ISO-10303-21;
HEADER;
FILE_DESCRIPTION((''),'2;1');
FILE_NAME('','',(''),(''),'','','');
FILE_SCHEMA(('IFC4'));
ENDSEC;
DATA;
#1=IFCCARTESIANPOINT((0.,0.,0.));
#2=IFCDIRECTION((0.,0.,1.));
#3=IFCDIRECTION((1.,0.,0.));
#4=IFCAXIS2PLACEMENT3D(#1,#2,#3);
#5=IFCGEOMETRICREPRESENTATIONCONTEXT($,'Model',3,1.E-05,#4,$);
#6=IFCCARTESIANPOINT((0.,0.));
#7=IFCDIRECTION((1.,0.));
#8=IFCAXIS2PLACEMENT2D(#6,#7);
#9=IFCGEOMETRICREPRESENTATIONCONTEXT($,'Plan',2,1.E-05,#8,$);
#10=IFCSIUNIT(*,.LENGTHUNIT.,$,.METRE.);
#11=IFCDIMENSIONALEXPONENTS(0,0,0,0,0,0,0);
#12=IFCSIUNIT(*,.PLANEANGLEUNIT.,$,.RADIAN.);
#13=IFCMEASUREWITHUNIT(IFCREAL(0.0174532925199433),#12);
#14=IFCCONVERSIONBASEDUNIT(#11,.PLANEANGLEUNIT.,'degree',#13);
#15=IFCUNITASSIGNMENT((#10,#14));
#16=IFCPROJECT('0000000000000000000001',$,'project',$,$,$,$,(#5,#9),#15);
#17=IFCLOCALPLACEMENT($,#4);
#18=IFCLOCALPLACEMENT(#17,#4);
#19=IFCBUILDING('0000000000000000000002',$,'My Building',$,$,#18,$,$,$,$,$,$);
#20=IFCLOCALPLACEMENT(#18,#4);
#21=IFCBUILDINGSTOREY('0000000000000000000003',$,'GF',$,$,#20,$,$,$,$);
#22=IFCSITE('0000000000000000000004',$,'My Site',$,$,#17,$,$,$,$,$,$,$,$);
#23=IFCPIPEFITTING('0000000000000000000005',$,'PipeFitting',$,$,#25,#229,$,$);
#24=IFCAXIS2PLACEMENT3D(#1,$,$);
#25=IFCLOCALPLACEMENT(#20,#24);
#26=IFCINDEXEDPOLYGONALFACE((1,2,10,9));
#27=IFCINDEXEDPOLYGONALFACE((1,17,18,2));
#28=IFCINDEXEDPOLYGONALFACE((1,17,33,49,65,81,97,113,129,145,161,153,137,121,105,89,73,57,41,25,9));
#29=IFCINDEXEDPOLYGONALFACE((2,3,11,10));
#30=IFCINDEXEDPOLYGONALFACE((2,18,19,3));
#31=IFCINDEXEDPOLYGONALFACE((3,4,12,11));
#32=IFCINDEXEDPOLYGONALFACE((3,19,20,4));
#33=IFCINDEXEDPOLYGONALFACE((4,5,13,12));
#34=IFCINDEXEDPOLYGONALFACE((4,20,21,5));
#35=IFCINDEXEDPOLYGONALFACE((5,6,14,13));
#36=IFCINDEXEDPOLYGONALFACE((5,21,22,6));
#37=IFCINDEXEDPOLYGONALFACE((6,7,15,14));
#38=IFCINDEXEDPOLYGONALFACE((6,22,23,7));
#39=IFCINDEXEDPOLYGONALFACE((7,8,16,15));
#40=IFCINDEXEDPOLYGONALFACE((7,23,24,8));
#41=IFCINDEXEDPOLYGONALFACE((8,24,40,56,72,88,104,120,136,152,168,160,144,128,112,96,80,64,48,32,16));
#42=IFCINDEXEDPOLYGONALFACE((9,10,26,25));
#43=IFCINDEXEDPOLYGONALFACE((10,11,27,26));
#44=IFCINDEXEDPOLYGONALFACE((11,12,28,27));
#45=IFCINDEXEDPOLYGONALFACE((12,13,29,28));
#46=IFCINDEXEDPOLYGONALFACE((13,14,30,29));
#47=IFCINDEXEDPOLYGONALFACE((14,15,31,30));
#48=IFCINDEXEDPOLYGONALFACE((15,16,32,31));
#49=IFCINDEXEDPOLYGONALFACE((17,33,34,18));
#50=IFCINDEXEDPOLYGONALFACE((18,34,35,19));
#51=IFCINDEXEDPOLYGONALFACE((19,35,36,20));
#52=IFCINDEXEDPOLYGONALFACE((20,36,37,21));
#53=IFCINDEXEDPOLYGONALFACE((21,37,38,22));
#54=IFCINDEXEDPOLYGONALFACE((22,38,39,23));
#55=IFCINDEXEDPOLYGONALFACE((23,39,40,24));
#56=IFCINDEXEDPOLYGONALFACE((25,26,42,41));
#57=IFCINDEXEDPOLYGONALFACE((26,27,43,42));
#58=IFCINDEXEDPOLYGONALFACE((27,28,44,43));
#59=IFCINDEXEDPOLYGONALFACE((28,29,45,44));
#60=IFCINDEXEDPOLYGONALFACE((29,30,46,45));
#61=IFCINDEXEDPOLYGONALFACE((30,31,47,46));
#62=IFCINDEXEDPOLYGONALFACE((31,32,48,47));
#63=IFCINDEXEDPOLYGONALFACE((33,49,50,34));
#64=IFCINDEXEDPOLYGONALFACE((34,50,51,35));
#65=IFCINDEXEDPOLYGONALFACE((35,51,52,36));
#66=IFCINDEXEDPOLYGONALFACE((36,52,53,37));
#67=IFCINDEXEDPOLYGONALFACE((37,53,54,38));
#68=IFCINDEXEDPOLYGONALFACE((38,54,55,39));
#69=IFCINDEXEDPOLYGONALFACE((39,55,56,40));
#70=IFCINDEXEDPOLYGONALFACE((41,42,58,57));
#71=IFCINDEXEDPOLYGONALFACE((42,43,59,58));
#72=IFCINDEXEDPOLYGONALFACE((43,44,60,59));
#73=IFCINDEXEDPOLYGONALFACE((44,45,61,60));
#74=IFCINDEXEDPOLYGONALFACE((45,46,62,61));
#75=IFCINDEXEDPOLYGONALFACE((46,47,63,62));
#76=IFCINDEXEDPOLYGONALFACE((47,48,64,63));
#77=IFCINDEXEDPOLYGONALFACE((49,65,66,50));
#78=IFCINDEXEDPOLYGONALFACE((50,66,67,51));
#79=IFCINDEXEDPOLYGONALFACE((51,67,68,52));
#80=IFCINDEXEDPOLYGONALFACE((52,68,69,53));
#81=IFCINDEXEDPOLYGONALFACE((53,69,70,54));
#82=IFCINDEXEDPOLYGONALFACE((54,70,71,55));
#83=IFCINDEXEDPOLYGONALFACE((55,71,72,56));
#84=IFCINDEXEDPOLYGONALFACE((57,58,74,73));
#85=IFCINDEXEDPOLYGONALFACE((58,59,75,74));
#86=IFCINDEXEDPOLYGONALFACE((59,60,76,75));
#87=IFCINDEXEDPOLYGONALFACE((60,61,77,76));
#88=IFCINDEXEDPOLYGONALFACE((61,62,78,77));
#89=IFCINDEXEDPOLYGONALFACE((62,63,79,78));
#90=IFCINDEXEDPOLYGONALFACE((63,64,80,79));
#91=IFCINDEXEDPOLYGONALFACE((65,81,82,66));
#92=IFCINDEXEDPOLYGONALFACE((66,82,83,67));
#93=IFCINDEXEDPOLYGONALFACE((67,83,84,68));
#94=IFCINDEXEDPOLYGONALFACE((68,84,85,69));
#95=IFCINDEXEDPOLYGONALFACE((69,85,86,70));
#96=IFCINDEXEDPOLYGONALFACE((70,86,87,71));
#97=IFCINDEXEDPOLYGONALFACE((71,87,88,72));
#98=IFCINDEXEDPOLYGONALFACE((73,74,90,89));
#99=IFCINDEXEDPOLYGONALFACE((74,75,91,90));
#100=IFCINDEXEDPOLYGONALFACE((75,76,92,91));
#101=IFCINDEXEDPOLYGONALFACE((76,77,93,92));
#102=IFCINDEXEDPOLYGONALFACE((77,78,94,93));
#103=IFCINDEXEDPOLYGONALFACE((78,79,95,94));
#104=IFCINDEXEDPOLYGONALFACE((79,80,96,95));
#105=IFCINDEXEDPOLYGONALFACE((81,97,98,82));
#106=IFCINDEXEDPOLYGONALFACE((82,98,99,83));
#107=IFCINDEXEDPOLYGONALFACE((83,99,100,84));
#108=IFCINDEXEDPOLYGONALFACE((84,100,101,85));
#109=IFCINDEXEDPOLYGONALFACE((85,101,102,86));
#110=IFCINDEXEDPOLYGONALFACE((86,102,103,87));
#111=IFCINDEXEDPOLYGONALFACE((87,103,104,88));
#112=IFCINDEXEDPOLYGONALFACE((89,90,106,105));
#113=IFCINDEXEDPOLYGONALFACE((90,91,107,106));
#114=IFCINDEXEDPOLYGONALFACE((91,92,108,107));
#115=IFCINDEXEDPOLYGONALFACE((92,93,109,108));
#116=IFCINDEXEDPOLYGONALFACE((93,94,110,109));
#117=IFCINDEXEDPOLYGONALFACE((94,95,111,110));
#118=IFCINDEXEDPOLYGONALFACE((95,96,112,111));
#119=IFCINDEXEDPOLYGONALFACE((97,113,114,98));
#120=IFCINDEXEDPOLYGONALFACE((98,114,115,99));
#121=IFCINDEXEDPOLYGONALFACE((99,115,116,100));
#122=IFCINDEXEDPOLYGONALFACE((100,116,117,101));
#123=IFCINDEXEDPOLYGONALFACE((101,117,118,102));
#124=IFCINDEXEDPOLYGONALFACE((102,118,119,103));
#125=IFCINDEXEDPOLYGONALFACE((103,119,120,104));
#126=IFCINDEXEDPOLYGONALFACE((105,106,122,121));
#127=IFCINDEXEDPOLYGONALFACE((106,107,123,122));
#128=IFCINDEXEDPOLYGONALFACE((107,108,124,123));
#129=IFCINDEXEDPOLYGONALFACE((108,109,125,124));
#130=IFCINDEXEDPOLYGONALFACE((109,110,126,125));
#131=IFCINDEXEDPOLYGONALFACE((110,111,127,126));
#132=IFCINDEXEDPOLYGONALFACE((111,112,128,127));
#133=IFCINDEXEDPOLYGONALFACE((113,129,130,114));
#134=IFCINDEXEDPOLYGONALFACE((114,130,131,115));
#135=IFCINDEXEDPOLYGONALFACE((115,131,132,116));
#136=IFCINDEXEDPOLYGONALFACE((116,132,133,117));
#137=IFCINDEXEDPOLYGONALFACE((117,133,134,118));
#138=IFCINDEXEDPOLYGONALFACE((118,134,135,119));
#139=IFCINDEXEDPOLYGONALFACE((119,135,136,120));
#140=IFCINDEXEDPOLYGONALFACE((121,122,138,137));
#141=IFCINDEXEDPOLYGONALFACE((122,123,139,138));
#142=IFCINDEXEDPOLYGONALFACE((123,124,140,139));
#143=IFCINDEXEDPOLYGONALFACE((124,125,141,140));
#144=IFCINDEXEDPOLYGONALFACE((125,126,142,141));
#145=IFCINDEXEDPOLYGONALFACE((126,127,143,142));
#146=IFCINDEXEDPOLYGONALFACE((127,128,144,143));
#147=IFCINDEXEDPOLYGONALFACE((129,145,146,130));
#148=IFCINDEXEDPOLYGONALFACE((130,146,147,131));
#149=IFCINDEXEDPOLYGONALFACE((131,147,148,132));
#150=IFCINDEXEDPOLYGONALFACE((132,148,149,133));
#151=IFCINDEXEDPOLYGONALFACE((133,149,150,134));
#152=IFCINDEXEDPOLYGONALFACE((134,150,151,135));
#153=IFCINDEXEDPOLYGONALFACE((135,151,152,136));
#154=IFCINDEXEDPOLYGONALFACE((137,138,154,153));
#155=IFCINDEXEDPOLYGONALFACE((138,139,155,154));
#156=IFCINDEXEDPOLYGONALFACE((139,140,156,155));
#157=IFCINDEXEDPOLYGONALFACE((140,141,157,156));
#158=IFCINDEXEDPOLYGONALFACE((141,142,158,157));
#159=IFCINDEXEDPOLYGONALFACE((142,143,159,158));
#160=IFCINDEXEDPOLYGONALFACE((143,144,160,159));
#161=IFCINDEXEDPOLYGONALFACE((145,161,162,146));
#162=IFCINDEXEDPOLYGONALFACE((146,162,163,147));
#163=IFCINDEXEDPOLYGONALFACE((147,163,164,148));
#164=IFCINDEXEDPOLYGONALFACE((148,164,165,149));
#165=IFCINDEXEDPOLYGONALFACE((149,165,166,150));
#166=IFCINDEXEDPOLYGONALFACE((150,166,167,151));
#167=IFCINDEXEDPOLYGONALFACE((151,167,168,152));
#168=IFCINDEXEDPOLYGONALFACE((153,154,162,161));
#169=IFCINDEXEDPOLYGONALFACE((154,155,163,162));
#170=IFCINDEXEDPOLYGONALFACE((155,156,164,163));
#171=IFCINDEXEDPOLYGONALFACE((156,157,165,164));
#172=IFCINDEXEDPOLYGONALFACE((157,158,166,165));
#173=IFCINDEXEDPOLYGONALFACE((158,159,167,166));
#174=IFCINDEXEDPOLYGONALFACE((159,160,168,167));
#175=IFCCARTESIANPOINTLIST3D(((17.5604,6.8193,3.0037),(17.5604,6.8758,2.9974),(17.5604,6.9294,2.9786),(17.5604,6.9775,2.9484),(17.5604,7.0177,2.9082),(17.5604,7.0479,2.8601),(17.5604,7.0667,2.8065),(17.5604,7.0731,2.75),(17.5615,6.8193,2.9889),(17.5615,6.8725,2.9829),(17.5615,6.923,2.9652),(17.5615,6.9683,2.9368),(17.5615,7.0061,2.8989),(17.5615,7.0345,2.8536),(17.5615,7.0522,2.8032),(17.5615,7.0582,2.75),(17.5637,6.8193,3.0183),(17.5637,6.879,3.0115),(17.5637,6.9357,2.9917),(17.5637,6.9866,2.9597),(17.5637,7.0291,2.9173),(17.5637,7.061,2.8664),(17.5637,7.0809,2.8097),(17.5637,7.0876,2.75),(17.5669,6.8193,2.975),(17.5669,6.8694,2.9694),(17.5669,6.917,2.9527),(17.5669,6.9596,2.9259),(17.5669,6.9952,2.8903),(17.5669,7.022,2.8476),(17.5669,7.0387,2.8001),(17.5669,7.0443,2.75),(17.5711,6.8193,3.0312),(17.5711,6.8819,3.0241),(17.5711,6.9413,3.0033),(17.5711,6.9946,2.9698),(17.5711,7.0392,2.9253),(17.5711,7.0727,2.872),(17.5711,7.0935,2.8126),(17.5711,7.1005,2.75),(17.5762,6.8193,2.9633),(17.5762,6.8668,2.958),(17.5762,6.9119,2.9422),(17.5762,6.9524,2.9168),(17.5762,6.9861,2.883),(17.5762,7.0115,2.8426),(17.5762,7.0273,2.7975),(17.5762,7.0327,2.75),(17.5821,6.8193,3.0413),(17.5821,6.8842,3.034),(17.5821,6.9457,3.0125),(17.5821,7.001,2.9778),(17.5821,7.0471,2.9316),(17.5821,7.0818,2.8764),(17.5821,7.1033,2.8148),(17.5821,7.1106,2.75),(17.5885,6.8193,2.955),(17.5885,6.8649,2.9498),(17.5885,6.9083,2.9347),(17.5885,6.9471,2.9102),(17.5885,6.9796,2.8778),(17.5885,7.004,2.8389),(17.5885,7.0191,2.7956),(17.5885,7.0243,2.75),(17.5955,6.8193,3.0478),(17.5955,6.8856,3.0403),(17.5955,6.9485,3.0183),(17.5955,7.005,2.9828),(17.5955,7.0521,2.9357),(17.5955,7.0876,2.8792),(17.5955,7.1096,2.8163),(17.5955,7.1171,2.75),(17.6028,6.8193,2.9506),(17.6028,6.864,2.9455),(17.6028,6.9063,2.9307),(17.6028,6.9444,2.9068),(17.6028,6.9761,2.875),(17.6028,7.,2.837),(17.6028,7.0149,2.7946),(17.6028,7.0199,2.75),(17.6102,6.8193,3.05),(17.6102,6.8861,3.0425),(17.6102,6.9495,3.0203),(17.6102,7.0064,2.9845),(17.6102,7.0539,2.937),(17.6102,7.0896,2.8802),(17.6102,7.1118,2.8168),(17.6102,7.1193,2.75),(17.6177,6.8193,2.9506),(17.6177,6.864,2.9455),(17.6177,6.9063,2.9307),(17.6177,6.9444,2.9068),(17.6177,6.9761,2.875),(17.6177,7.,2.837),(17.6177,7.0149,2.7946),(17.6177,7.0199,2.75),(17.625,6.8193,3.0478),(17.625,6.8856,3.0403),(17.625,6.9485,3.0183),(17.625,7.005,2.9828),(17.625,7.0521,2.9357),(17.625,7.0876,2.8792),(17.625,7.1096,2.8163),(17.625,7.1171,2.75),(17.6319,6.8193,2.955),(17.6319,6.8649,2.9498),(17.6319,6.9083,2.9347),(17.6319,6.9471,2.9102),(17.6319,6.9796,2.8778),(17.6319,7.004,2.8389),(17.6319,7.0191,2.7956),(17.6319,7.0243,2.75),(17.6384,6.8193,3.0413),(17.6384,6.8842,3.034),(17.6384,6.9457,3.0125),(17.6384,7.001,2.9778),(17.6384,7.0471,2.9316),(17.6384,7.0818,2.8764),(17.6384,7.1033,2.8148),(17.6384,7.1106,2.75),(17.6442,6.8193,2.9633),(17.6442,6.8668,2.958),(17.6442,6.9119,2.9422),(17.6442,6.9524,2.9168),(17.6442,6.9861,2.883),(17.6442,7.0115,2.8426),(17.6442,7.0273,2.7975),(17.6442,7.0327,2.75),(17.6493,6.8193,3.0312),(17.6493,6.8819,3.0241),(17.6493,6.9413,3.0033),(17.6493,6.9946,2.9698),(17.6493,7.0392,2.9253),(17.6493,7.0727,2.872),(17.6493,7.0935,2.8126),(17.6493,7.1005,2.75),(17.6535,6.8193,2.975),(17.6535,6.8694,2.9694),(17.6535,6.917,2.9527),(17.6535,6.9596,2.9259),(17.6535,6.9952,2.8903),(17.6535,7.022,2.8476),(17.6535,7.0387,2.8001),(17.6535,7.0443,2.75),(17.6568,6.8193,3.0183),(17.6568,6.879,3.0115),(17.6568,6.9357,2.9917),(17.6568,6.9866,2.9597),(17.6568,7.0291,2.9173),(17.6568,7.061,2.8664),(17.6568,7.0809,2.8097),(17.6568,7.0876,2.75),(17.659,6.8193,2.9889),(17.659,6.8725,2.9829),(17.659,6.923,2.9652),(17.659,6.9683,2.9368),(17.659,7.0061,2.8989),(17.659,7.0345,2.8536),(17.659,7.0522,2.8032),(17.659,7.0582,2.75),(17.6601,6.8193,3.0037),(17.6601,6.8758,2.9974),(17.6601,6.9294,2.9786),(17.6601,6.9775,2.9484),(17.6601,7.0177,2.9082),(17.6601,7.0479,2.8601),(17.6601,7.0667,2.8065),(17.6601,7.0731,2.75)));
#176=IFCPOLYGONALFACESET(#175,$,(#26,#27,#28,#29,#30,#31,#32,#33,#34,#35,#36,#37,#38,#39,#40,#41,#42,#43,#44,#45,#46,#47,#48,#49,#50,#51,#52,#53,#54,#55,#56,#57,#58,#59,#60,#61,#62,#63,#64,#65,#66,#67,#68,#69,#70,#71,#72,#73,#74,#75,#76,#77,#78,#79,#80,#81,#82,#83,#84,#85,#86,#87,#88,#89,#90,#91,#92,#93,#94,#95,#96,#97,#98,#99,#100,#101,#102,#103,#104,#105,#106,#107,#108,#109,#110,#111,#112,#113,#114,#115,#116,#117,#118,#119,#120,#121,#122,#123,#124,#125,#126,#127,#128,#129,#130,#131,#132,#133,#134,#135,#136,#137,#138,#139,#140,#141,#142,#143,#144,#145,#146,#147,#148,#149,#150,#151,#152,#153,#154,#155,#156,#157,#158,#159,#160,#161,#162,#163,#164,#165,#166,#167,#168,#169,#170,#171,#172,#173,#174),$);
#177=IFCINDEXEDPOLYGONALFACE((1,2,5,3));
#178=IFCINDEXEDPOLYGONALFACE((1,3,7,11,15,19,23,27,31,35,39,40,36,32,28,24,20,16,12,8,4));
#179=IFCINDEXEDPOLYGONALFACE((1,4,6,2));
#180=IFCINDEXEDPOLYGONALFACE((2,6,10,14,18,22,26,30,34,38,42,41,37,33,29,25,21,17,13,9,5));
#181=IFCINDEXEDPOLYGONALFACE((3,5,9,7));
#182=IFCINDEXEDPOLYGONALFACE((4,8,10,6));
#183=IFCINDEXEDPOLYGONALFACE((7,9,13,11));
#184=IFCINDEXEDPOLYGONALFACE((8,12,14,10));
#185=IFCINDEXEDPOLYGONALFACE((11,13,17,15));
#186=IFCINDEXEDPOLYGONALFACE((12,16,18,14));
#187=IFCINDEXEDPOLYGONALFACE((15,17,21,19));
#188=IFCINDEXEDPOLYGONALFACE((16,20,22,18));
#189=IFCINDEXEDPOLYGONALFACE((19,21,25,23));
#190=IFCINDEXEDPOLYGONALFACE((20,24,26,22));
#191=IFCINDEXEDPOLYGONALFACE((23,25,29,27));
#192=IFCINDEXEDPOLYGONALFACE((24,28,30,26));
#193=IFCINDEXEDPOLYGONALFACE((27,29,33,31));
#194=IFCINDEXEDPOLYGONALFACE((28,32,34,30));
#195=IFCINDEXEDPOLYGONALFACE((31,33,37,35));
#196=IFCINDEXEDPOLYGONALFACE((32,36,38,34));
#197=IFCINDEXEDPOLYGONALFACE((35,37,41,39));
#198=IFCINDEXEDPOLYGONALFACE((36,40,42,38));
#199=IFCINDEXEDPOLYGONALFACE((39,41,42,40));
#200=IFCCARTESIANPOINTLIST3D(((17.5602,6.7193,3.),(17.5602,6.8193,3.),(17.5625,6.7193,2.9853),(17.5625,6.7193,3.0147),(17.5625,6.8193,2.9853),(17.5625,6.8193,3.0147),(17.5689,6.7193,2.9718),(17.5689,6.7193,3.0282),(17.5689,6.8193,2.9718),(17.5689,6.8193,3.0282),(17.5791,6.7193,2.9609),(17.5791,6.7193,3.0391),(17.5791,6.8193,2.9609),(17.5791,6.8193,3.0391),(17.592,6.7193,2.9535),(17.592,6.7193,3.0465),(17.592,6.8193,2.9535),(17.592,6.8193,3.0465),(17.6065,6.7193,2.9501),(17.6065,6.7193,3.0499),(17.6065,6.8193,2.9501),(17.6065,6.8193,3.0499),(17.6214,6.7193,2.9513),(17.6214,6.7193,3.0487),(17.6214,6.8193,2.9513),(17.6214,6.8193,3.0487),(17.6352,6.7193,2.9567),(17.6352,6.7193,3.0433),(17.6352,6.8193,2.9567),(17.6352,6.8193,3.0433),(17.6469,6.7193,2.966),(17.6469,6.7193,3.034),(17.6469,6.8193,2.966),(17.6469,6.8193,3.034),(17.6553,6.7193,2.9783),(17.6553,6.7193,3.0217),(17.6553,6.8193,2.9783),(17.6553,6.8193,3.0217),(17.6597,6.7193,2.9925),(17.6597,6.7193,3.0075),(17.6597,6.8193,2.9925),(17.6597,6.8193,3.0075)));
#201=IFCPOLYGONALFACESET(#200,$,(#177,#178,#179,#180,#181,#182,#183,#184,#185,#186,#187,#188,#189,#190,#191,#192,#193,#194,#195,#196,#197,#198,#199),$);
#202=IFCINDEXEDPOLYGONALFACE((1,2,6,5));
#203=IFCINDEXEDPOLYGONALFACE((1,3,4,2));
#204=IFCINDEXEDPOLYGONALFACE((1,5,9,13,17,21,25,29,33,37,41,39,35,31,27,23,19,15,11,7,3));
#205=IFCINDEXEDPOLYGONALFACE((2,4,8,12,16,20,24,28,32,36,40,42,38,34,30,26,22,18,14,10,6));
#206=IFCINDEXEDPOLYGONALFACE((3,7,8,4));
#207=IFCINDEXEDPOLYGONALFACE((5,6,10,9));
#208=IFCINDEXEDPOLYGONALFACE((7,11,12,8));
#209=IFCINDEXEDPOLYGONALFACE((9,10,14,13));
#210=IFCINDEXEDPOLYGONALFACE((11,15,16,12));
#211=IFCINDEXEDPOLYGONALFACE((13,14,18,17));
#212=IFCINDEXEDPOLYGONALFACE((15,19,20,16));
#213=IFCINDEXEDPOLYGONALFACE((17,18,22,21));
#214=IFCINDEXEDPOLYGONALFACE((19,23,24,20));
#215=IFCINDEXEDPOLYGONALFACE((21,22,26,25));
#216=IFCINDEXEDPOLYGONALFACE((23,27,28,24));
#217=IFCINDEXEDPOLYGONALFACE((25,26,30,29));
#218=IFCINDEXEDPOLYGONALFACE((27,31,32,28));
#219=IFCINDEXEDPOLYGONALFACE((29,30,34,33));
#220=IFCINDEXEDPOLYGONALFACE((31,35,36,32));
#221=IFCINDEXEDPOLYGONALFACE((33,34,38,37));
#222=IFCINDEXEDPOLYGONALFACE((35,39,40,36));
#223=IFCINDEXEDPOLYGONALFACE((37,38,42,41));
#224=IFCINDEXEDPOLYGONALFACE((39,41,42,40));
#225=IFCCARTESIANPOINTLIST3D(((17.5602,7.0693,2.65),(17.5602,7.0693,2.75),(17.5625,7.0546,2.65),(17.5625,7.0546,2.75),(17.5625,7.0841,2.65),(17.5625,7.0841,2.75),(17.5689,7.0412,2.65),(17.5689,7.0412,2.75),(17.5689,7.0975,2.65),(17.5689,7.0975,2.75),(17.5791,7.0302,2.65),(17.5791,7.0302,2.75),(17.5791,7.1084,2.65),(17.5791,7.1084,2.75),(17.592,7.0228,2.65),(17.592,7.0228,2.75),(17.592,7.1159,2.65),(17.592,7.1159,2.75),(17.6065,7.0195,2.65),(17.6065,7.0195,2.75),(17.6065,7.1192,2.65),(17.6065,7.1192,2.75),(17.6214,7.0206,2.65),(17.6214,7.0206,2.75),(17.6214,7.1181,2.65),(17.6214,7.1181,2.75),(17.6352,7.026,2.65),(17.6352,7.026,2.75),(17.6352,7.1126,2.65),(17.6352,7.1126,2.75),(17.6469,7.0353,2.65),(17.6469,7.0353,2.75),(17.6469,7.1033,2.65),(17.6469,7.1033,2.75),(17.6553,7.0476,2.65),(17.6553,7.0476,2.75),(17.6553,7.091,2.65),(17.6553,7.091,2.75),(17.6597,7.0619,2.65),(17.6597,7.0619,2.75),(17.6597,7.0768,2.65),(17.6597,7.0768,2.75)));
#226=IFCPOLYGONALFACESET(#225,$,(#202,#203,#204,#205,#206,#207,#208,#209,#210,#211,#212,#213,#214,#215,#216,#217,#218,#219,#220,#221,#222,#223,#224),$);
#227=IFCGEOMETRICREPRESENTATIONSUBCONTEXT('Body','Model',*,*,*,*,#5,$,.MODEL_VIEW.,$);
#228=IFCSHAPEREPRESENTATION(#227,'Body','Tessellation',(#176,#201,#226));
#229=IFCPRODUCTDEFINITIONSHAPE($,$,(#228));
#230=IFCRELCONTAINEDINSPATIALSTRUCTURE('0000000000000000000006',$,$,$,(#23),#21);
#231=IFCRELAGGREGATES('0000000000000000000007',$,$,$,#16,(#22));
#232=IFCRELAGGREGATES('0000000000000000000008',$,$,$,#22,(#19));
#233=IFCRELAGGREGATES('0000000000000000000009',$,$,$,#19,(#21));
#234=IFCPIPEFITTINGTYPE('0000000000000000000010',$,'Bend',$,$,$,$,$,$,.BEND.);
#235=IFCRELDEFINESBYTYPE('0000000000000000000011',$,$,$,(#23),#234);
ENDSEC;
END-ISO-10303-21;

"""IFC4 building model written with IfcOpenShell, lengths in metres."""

from ifc_helpers import new_model, entity, si_unit, converted_unit, frame, origin_with_axes, origin_2d_with_axis, place, context, subcontext, project, spatial, circle, extrude, source, transform, mapped, type_object, type_shapes, element, save


model = new_model("IFC4")

# Units and contexts
model_context = context("Model", 3, precision=1e-05, world=origin_with_axes())
plan_context = context("Plan", 2, precision=1e-05, world=origin_2d_with_axis())
body_context_1 = subcontext(model_context, "Body", "Model", "MODEL_VIEW")
ifc_project = project(units=[si_unit("LENGTHUNIT", "METRE"), converted_unit("PLANEANGLEUNIT", "degree", entity("IfcReal", 0.0174532925199433), si_unit("PLANEANGLEUNIT", "RADIAN"), dimensions=[0, 0, 0, 0, 0, 0, 0])], contexts=[model_context, plan_context])

# Site, building, storey
site_placement = place(None, origin_with_axes())
site = spatial("IfcSite", under=ifc_project, at=site_placement, Name="My Site")
building_placement = place(site_placement, origin_with_axes())
building = spatial("IfcBuilding", under=site, at=building_placement, Name="My Building")
storey_placement = place(building_placement, origin_with_axes())
storey = spatial("IfcBuildingStorey", under=building, at=storey_placement, Name="GF")

# Pipe fitting
pipe_fitting_type = type_object("IfcPipeFittingType", Name="Bend", PredefinedType="BEND")
shared_shape_1 = source(origin_with_axes(), body_context_1, "Body", "SolidModel", [
    entity("IfcSweptDiskSolid", entity("IfcIndexedPolyCurve", entity("IfcCartesianPointList3D", [[0.0, 0.0, 0.1], [0.0, -0.0732, 0.2768], [0.0, -0.25, 0.35]]), [entity("IfcArcIndex", [1, 2, 3])]), 0.05),
    extrude(circle(Radius=0.05), origin_with_axes(), (0.0, 0.0, 1.0), 0.1),
    extrude(circle(Radius=0.05), frame((0.0, -0.25, 0.35), z_axis=(0.0, -1.0, 0.0), x_axis=(1.0, 0.0, 0.0)), (0.0, 0.0, 1.0), 0.1),
])
type_shapes(pipe_fitting_type, [shared_shape_1])
for number, where, z_axis, x_axis, name in (
    (1, (17.6102, 6.7193, 3.0), (0.0, 1.0, 0.0), (-1.0, 0.0, 0.0), "PipeFitting"),
):
    element("IfcPipeFitting", number, at=place(storey_placement, frame(where, z_axis=z_axis, x_axis=x_axis)), inside=storey, type_object=pipe_fitting_type, Name=name, context=body_context_1, shape_type="MappedRepresentation", body=[
        mapped(shared_shape_1, transform((0.0, 0.0, 0.0), x_axis=(1.0, 0.0, 0.0), y_axis=(0.0, 1.0, 0.0), z_axis=(0.0, 0.0, 1.0), scale=1.0)),
    ])

save(model, "model.ifc")
